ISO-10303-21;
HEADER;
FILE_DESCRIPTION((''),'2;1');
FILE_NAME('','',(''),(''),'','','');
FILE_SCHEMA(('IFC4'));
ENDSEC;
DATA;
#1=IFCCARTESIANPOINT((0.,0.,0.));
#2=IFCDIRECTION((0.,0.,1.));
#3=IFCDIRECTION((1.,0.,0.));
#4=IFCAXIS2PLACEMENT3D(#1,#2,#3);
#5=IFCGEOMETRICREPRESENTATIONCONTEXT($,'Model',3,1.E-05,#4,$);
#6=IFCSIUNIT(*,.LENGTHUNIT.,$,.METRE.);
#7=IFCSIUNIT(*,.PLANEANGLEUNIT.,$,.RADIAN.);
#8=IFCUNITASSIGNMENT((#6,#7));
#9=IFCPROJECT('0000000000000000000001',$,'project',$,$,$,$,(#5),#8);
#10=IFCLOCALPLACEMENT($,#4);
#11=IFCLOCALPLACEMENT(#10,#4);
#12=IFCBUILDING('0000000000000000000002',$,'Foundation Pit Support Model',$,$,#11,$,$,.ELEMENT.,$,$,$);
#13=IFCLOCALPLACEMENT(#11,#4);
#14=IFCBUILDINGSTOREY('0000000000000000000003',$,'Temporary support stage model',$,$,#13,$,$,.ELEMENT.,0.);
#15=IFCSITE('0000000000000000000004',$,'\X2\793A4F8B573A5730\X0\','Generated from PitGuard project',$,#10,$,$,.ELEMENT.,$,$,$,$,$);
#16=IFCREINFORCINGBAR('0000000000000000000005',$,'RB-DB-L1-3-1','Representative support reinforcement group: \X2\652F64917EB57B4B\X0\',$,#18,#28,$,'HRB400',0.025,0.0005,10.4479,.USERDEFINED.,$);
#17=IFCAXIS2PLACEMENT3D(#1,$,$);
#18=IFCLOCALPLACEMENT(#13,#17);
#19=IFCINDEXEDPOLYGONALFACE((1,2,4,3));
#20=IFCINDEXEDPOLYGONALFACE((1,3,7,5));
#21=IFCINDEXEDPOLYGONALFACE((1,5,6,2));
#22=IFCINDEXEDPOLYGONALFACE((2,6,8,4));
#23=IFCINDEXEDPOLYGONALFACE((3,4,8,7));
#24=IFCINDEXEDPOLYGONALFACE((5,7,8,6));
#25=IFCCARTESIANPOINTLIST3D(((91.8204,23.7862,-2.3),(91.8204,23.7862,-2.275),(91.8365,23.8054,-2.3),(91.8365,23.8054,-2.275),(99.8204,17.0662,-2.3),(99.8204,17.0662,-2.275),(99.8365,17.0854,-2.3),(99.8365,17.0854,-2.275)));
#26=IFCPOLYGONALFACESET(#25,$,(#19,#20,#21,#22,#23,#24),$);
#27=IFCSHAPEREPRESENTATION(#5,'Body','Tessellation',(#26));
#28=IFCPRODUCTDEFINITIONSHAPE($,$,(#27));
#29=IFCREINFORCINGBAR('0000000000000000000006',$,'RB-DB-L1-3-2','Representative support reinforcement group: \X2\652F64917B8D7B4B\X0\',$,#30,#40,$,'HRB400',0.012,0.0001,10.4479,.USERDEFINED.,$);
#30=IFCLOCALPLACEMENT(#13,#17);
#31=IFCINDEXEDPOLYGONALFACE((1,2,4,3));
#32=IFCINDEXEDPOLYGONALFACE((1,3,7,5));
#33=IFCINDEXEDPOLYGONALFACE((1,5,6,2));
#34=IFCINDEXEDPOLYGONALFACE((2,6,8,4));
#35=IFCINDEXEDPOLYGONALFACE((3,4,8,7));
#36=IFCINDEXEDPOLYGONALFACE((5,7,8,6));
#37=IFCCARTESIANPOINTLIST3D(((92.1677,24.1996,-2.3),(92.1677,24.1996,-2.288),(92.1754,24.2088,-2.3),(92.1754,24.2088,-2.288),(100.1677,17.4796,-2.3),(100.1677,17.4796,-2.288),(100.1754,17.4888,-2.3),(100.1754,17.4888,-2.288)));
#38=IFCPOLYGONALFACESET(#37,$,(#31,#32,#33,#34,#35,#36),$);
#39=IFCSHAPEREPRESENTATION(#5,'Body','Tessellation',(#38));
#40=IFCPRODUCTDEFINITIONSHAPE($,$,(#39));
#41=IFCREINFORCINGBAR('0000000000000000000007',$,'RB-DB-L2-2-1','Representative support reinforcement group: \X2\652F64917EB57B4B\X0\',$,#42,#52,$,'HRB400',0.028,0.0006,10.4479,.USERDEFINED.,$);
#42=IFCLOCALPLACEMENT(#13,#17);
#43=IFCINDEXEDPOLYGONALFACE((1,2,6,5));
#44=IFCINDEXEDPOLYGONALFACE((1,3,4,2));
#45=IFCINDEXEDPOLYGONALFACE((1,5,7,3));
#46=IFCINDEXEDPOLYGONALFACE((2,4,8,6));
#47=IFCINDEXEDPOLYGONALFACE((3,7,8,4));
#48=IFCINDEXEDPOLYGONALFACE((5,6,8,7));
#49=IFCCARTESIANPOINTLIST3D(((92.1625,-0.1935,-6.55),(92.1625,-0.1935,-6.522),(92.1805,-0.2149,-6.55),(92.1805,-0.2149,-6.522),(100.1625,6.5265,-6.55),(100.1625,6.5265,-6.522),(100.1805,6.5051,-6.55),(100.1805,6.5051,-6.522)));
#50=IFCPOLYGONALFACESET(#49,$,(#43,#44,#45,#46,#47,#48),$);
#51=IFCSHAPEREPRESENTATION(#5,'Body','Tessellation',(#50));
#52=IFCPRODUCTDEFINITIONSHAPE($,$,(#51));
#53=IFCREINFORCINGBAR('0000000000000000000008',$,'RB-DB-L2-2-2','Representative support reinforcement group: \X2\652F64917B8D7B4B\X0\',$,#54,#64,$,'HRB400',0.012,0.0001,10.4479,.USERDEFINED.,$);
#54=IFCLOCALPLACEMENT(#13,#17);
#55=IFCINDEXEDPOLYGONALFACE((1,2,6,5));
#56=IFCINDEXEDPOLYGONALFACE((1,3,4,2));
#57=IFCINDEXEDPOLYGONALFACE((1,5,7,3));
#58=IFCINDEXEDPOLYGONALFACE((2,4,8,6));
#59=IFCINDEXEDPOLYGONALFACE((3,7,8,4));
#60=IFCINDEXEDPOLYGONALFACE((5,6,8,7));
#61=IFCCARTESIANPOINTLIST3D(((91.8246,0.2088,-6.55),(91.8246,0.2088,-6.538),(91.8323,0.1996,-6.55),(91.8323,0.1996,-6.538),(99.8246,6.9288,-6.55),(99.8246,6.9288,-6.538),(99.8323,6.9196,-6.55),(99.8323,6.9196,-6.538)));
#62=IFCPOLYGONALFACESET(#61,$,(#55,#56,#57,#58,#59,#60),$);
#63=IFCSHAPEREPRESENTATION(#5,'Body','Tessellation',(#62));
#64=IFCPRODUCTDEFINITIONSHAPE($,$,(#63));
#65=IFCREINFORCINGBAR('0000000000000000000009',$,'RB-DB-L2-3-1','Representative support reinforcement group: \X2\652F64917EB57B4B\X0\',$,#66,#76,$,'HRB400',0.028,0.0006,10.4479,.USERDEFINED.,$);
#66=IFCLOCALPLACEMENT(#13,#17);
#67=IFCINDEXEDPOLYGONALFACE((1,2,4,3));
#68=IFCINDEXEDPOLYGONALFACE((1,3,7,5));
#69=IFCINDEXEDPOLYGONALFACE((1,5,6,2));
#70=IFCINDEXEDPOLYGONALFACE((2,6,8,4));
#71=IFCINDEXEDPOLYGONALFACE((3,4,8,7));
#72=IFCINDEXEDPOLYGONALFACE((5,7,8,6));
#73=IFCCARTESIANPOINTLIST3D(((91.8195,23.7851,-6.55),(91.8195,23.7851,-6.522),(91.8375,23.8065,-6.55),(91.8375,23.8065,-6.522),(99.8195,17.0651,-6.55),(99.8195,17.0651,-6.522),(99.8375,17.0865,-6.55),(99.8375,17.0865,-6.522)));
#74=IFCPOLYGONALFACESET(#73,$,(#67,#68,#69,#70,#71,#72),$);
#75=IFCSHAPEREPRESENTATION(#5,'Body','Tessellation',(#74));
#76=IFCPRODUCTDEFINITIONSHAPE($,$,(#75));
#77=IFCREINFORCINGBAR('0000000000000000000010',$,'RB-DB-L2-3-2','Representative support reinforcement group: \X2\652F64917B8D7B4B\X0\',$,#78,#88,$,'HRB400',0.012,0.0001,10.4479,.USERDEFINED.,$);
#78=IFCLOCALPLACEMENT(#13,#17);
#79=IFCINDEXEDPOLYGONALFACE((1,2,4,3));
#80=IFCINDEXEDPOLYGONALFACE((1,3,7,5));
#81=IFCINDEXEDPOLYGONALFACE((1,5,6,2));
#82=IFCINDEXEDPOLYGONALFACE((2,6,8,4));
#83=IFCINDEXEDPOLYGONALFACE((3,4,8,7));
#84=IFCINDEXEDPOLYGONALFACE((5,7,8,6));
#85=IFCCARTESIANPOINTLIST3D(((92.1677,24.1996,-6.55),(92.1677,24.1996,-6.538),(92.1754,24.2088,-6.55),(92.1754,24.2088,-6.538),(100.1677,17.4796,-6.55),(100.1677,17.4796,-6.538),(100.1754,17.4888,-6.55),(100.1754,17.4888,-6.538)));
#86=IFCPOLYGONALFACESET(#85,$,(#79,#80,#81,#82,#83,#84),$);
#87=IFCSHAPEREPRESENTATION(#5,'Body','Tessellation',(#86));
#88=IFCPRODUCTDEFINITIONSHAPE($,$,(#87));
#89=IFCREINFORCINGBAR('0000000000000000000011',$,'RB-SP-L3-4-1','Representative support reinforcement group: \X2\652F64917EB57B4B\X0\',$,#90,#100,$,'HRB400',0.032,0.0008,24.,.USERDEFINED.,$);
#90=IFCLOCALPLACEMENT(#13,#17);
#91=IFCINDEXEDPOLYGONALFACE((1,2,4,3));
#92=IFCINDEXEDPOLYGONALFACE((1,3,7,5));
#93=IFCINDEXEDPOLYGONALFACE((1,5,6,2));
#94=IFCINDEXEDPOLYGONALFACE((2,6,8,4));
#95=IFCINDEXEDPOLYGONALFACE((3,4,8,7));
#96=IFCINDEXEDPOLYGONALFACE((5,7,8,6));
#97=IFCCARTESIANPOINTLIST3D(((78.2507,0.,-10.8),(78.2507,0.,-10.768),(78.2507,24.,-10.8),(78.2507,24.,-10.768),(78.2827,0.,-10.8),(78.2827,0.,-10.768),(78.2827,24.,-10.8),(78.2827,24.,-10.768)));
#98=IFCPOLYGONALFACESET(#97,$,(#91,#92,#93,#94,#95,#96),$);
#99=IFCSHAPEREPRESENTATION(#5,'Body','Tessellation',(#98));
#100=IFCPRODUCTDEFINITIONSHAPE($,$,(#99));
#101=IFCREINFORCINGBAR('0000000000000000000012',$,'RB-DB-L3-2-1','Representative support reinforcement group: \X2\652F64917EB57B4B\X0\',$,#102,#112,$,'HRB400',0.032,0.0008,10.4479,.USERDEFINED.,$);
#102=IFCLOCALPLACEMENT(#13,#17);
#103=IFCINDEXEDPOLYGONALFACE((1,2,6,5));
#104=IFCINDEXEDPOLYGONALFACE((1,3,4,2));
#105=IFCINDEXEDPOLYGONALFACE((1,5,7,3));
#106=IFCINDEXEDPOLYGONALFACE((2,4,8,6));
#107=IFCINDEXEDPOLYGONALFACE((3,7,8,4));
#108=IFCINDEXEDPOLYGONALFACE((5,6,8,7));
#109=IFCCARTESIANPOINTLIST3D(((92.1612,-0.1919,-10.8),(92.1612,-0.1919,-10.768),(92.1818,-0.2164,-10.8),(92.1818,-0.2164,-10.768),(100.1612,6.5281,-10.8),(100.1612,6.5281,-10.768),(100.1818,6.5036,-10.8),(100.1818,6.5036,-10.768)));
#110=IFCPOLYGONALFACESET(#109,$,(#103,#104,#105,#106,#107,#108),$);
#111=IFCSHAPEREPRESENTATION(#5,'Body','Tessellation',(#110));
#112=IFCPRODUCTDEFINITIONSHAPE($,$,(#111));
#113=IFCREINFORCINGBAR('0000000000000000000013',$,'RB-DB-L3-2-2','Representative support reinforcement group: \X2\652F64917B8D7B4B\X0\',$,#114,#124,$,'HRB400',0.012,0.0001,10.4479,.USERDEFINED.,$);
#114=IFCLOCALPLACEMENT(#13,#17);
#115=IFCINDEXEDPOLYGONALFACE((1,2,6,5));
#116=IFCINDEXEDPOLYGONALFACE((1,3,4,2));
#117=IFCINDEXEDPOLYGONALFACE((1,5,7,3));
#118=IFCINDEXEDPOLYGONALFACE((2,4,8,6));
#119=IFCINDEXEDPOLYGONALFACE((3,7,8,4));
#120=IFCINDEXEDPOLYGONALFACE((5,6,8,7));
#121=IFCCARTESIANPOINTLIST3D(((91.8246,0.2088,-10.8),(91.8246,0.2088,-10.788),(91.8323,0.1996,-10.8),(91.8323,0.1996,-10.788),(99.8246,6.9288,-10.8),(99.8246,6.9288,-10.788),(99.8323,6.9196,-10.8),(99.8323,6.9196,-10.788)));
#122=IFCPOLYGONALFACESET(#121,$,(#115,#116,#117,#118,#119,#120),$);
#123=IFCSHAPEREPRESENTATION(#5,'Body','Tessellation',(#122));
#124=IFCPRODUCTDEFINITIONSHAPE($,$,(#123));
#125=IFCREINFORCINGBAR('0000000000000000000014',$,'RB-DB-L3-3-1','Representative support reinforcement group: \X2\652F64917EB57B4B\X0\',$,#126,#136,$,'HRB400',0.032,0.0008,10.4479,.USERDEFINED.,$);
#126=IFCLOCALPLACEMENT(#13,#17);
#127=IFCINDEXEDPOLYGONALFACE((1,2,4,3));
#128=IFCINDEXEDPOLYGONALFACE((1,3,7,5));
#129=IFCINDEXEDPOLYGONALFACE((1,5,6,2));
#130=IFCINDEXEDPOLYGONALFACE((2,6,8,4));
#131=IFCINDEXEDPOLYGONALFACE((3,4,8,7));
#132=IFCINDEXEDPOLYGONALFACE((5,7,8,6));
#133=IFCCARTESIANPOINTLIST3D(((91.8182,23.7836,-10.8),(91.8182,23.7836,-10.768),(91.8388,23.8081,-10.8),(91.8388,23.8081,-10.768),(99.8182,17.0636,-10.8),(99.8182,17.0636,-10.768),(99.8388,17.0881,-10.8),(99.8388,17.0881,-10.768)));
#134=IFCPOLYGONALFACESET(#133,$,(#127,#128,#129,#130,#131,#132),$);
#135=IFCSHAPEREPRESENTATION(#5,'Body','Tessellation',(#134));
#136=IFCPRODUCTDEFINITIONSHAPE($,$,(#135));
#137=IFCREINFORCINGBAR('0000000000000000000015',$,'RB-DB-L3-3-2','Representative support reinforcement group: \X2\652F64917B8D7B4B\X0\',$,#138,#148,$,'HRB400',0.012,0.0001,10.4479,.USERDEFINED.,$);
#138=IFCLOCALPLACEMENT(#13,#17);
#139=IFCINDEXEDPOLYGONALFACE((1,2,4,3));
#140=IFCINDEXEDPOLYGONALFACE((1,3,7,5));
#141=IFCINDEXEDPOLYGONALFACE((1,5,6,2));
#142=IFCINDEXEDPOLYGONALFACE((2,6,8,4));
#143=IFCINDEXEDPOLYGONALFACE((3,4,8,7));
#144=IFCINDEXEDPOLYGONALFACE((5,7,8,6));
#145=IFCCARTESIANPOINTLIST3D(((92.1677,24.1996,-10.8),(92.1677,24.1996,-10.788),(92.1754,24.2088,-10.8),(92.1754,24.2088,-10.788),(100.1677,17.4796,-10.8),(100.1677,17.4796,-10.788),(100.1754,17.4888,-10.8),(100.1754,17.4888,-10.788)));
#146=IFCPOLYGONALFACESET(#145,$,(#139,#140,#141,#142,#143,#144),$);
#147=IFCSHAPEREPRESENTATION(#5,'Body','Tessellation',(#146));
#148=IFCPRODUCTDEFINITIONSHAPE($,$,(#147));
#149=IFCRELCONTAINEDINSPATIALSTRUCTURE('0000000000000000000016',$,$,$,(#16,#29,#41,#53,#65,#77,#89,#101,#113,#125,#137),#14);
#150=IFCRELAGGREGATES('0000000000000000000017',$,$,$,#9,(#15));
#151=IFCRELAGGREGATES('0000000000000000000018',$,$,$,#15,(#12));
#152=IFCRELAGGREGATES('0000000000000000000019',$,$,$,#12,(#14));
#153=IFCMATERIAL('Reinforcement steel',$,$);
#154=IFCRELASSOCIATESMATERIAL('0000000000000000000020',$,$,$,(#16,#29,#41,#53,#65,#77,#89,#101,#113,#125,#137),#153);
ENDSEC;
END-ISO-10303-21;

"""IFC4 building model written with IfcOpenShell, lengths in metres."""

from ifc_helpers import new_model, si_unit, frame, origin_with_axes, origin_2d, place, context, project, spatial, rectangle, extrude, material, element, save


model = new_model("IFC4")

# Units and contexts
model_context = context("Model", 3, precision=1e-05, world=origin_with_axes())
ifc_project = project(units=[si_unit("LENGTHUNIT", "METRE"), si_unit("PLANEANGLEUNIT", "RADIAN")], contexts=[model_context])

# Site, building, storey
site_placement = place(None, origin_with_axes())
site = spatial("IfcSite", under=ifc_project, at=site_placement, Name="示例场地", Description="Generated from PitGuard project", CompositionType="ELEMENT")
building_placement = place(site_placement, origin_with_axes())
building = spatial("IfcBuilding", under=site, at=building_placement, Name="Foundation Pit Support Model", CompositionType="ELEMENT")
storey_placement = place(building_placement, origin_with_axes())
storey = spatial("IfcBuildingStorey", under=building, at=storey_placement, Name="Temporary support stage model", CompositionType="ELEMENT", Elevation=0.0)

# Reinforcing bars
ifc_material_1 = material(Name="Reinforcement steel")
reinforcing_bar_1_placement = place(storey_placement, frame((95.8285, 20.4358, -2.3), z_axis=(0.0, 0.0, 1.0), x_axis=(0.765705, -0.643192, 0.0)))
element("IfcReinforcingBar", 1, at=reinforcing_bar_1_placement, inside=storey, material=ifc_material_1, Name="RB-DB-L1-3-1", Description="Representative support reinforcement group: 支撑纵筋", SteelGrade="HRB400", BarLength=10.4479, CrossSectionArea=0.0005, NominalDiameter=0.025, PredefinedType="USERDEFINED", context=model_context, shape_type="SweptSolid", body=[
    extrude(rectangle(XDim=10.4479, YDim=0.025, at=origin_2d()), origin_with_axes(), (0.0, 0.0, 1.0), 0.025),
])
reinforcing_bar_2_placement = place(storey_placement, frame((96.1715, 20.8442, -2.3), z_axis=(0.0, 0.0, 1.0), x_axis=(0.765705, -0.643192, 0.0)))
element("IfcReinforcingBar", 2, at=reinforcing_bar_2_placement, inside=storey, material=ifc_material_1, Name="RB-DB-L1-3-2", Description="Representative support reinforcement group: 支撑箍筋", SteelGrade="HRB400", BarLength=10.4479, CrossSectionArea=0.0001, NominalDiameter=0.012, PredefinedType="USERDEFINED", context=model_context, shape_type="SweptSolid", body=[
    extrude(rectangle(XDim=10.4479, YDim=0.012, at=origin_2d()), origin_with_axes(), (0.0, 0.0, 1.0), 0.012),
])
reinforcing_bar_3_placement = place(storey_placement, frame((96.1715, 3.1558, -6.55), z_axis=(0.0, 0.0, 1.0), x_axis=(0.765705, 0.643192, 0.0)))
element("IfcReinforcingBar", 3, at=reinforcing_bar_3_placement, inside=storey, material=ifc_material_1, Name="RB-DB-L2-2-1", Description="Representative support reinforcement group: 支撑纵筋", SteelGrade="HRB400", BarLength=10.4479, CrossSectionArea=0.0006, NominalDiameter=0.028, PredefinedType="USERDEFINED", context=model_context, shape_type="SweptSolid", body=[
    extrude(rectangle(XDim=10.4479, YDim=0.028, at=origin_2d()), origin_with_axes(), (0.0, 0.0, 1.0), 0.028),
])
reinforcing_bar_4_placement = place(storey_placement, frame((95.8285, 3.5642, -6.55), z_axis=(0.0, 0.0, 1.0), x_axis=(0.765705, 0.643192, 0.0)))
element("IfcReinforcingBar", 4, at=reinforcing_bar_4_placement, inside=storey, material=ifc_material_1, Name="RB-DB-L2-2-2", Description="Representative support reinforcement group: 支撑箍筋", SteelGrade="HRB400", BarLength=10.4479, CrossSectionArea=0.0001, NominalDiameter=0.012, PredefinedType="USERDEFINED", context=model_context, shape_type="SweptSolid", body=[
    extrude(rectangle(XDim=10.4479, YDim=0.012, at=origin_2d()), origin_with_axes(), (0.0, 0.0, 1.0), 0.012),
])
reinforcing_bar_5_placement = place(storey_placement, frame((95.8285, 20.4358, -6.55), z_axis=(0.0, 0.0, 1.0), x_axis=(0.765705, -0.643192, 0.0)))
element("IfcReinforcingBar", 5, at=reinforcing_bar_5_placement, inside=storey, material=ifc_material_1, Name="RB-DB-L2-3-1", Description="Representative support reinforcement group: 支撑纵筋", SteelGrade="HRB400", BarLength=10.4479, CrossSectionArea=0.0006, NominalDiameter=0.028, PredefinedType="USERDEFINED", context=model_context, shape_type="SweptSolid", body=[
    extrude(rectangle(XDim=10.4479, YDim=0.028, at=origin_2d()), origin_with_axes(), (0.0, 0.0, 1.0), 0.028),
])
reinforcing_bar_6_placement = place(storey_placement, frame((96.1715, 20.8442, -6.55), z_axis=(0.0, 0.0, 1.0), x_axis=(0.765705, -0.643192, 0.0)))
element("IfcReinforcingBar", 6, at=reinforcing_bar_6_placement, inside=storey, material=ifc_material_1, Name="RB-DB-L2-3-2", Description="Representative support reinforcement group: 支撑箍筋", SteelGrade="HRB400", BarLength=10.4479, CrossSectionArea=0.0001, NominalDiameter=0.012, PredefinedType="USERDEFINED", context=model_context, shape_type="SweptSolid", body=[
    extrude(rectangle(XDim=10.4479, YDim=0.012, at=origin_2d()), origin_with_axes(), (0.0, 0.0, 1.0), 0.012),
])
reinforcing_bar_7_placement = place(storey_placement, frame((78.2667, 12.0, -10.8), z_axis=(0.0, 0.0, 1.0), x_axis=(0.0, 1.0, 0.0)))
element("IfcReinforcingBar", 7, at=reinforcing_bar_7_placement, inside=storey, material=ifc_material_1, Name="RB-SP-L3-4-1", Description="Representative support reinforcement group: 支撑纵筋", SteelGrade="HRB400", BarLength=24.0, CrossSectionArea=0.0008, NominalDiameter=0.032, PredefinedType="USERDEFINED", context=model_context, shape_type="SweptSolid", body=[
    extrude(rectangle(XDim=24.0, YDim=0.032, at=origin_2d()), origin_with_axes(), (0.0, 0.0, 1.0), 0.032),
])
reinforcing_bar_8_placement = place(storey_placement, frame((96.1715, 3.1558, -10.8), z_axis=(0.0, 0.0, 1.0), x_axis=(0.765705, 0.643192, 0.0)))
element("IfcReinforcingBar", 8, at=reinforcing_bar_8_placement, inside=storey, material=ifc_material_1, Name="RB-DB-L3-2-1", Description="Representative support reinforcement group: 支撑纵筋", SteelGrade="HRB400", BarLength=10.4479, CrossSectionArea=0.0008, NominalDiameter=0.032, PredefinedType="USERDEFINED", context=model_context, shape_type="SweptSolid", body=[
    extrude(rectangle(XDim=10.4479, YDim=0.032, at=origin_2d()), origin_with_axes(), (0.0, 0.0, 1.0), 0.032),
])
reinforcing_bar_9_placement = place(storey_placement, frame((95.8285, 3.5642, -10.8), z_axis=(0.0, 0.0, 1.0), x_axis=(0.765705, 0.643192, 0.0)))
element("IfcReinforcingBar", 9, at=reinforcing_bar_9_placement, inside=storey, material=ifc_material_1, Name="RB-DB-L3-2-2", Description="Representative support reinforcement group: 支撑箍筋", SteelGrade="HRB400", BarLength=10.4479, CrossSectionArea=0.0001, NominalDiameter=0.012, PredefinedType="USERDEFINED", context=model_context, shape_type="SweptSolid", body=[
    extrude(rectangle(XDim=10.4479, YDim=0.012, at=origin_2d()), origin_with_axes(), (0.0, 0.0, 1.0), 0.012),
])
reinforcing_bar_10_placement = place(storey_placement, frame((95.8285, 20.4358, -10.8), z_axis=(0.0, 0.0, 1.0), x_axis=(0.765705, -0.643192, 0.0)))
element("IfcReinforcingBar", 10, at=reinforcing_bar_10_placement, inside=storey, material=ifc_material_1, Name="RB-DB-L3-3-1", Description="Representative support reinforcement group: 支撑纵筋", SteelGrade="HRB400", BarLength=10.4479, CrossSectionArea=0.0008, NominalDiameter=0.032, PredefinedType="USERDEFINED", context=model_context, shape_type="SweptSolid", body=[
    extrude(rectangle(XDim=10.4479, YDim=0.032, at=origin_2d()), origin_with_axes(), (0.0, 0.0, 1.0), 0.032),
])
reinforcing_bar_11_placement = place(storey_placement, frame((96.1715, 20.8442, -10.8), z_axis=(0.0, 0.0, 1.0), x_axis=(0.765705, -0.643192, 0.0)))
element("IfcReinforcingBar", 11, at=reinforcing_bar_11_placement, inside=storey, material=ifc_material_1, Name="RB-DB-L3-3-2", Description="Representative support reinforcement group: 支撑箍筋", SteelGrade="HRB400", BarLength=10.4479, CrossSectionArea=0.0001, NominalDiameter=0.012, PredefinedType="USERDEFINED", context=model_context, shape_type="SweptSolid", body=[
    extrude(rectangle(XDim=10.4479, YDim=0.012, at=origin_2d()), origin_with_axes(), (0.0, 0.0, 1.0), 0.012),
])

save(model, "model.ifc")
